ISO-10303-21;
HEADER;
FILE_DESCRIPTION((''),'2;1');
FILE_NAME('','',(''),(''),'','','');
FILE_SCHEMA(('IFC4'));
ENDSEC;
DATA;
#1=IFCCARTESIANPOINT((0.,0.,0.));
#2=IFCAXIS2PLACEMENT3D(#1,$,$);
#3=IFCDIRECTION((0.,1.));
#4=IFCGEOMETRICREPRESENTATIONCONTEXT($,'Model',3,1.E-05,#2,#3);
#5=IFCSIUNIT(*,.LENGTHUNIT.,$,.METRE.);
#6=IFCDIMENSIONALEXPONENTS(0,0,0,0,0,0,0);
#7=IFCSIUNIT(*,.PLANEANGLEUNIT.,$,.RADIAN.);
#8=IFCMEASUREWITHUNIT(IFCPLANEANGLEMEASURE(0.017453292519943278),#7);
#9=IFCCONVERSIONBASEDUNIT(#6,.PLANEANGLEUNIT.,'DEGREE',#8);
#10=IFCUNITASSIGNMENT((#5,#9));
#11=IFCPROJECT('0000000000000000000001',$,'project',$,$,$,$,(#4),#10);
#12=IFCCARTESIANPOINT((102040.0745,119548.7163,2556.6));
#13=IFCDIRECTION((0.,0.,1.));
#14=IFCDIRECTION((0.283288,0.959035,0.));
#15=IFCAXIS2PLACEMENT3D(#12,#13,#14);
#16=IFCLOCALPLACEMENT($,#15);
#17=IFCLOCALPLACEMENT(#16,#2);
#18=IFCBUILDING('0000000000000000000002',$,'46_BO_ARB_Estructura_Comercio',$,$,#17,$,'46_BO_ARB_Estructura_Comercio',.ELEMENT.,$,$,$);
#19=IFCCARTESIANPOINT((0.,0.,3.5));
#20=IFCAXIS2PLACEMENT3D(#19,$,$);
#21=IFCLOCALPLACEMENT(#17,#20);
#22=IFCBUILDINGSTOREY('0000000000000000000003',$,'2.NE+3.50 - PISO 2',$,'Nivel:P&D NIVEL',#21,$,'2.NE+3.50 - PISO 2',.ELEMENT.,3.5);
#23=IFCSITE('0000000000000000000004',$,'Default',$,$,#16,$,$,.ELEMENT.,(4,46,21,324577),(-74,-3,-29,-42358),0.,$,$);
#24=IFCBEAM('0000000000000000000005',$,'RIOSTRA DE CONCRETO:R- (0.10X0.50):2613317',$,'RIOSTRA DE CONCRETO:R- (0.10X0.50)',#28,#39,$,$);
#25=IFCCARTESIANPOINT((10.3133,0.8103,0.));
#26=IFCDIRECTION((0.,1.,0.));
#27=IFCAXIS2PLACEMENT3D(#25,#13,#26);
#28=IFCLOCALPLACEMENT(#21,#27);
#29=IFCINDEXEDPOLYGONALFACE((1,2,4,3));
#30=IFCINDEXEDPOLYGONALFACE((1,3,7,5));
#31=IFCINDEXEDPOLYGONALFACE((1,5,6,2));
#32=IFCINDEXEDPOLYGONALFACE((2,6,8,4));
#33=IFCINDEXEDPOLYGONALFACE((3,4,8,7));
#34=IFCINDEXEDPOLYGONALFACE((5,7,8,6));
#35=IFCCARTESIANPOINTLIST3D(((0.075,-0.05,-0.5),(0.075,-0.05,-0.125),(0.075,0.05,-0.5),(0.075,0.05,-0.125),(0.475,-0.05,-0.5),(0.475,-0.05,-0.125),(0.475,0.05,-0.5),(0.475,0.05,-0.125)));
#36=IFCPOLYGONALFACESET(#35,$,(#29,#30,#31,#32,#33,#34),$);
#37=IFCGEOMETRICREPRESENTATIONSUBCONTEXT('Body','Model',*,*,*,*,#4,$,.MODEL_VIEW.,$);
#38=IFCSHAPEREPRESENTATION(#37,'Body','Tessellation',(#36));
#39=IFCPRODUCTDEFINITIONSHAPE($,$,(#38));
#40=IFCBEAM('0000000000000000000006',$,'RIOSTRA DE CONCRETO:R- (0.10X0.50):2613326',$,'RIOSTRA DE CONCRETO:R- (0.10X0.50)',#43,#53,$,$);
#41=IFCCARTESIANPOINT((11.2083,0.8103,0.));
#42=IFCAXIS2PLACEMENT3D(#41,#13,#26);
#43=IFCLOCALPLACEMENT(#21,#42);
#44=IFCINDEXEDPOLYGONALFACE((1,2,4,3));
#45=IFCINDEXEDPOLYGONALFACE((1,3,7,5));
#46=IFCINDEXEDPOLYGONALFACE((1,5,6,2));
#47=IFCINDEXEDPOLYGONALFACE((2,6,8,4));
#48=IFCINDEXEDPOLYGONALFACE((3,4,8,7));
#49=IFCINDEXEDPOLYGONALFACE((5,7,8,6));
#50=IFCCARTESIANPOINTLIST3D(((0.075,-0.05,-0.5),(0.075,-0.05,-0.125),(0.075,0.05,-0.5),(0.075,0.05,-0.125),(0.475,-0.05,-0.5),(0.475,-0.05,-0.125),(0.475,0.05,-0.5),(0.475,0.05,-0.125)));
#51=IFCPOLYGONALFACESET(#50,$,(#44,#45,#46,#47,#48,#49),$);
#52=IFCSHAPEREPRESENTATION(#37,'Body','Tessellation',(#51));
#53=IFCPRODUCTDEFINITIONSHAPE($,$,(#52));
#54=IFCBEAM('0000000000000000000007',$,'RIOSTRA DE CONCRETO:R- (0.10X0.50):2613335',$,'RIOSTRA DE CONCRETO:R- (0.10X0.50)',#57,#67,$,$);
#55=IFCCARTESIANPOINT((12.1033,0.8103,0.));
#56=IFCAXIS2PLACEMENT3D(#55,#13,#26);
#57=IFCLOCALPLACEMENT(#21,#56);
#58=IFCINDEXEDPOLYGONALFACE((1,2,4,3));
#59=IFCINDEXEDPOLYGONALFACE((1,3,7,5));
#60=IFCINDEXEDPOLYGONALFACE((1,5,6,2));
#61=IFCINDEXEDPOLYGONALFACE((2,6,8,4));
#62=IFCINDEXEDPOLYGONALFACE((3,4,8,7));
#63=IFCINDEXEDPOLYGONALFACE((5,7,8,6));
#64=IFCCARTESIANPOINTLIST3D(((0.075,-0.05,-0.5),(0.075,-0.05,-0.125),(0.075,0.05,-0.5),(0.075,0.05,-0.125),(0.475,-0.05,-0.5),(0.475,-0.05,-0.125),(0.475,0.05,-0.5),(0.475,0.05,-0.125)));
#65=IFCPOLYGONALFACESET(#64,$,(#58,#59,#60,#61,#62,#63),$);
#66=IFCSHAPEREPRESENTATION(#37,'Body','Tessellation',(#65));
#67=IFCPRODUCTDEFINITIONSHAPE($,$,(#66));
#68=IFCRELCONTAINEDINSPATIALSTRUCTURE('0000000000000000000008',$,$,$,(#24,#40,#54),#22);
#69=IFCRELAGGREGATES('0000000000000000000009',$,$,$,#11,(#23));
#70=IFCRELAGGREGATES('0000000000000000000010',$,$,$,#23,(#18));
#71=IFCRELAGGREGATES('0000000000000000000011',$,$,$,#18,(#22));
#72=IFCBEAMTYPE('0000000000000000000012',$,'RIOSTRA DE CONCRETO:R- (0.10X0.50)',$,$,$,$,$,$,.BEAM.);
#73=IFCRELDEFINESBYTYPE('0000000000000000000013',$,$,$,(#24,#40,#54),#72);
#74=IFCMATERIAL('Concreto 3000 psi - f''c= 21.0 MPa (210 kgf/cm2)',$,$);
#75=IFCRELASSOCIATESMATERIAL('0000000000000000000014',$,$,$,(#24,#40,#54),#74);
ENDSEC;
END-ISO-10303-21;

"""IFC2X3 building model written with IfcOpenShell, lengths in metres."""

from ifc_helpers import new_model, entity, si_unit, converted_unit, direction, frame, frame_2d, origin, place, context, subcontext, project, spatial, rectangle, extrude, material, type_object, element, save


model = new_model("IFC2X3")

# Units and contexts
model_context = context("Model", 3, precision=1e-05, world=origin(), true_north=direction((0.0, 1.0)))
body_context = subcontext(model_context, "Body", "Model", "MODEL_VIEW")
ifc_project = project(units=[si_unit("LENGTHUNIT", "METRE"), converted_unit("PLANEANGLEUNIT", "DEGREE", entity("IfcPlaneAngleMeasure", 0.017453292519943278), si_unit("PLANEANGLEUNIT", "RADIAN"), dimensions=[0, 0, 0, 0, 0, 0, 0])], contexts=[model_context])

# Site, building, storey
site_placement = place(None, frame((102040.0745, 119548.7163, 2556.6), z_axis=(0.0, 0.0, 1.0), x_axis=(0.283288, 0.959035, 0.0)))
site = spatial("IfcSite", under=ifc_project, at=site_placement, Name="Default", CompositionType="ELEMENT", RefLatitude=(4, 46, 21, 324577), RefLongitude=(-74, -3, -29, -42358), RefElevation=0.0)
building_placement = place(site_placement, origin())
building = spatial("IfcBuilding", under=site, at=building_placement, Name="46_BO_ARB_Estructura_Comercio", LongName="46_BO_ARB_Estructura_Comercio", CompositionType="ELEMENT")
storey_placement = place(building_placement, frame((0.0, 0.0, 3.5)))
storey = spatial("IfcBuildingStorey", under=building, at=storey_placement, Name="2.NE+3.50 - PISO 2", ObjectType="Nivel:P&D NIVEL", LongName="2.NE+3.50 - PISO 2", CompositionType="ELEMENT", Elevation=3.5)

# Beams
ifc_material = material(Name="Concreto 3000 psi - f'c= 21.0 MPa (210 kgf/cm2)")
beam_type_1 = type_object("IfcBeamType", Name="RIOSTRA DE CONCRETO:R- (0.10X0.50)", PredefinedType="BEAM")
beam_1_placement = place(storey_placement, frame((10.3133, 0.8103, 0.0), z_axis=(0.0, 0.0, 1.0), x_axis=(0.0, 1.0, 0.0)))
element("IfcBeam", 1, at=beam_1_placement, inside=storey, type_object=beam_type_1, material=ifc_material, Name="RIOSTRA DE CONCRETO:R- (0.10X0.50):2613317", ObjectType="RIOSTRA DE CONCRETO:R- (0.10X0.50)", context=body_context, shape_type="SweptSolid", body=[
    extrude(rectangle(XDim=0.375, YDim=0.1, at=frame_2d((0.0, 0.0), x_axis=(1.0, 0.0))), frame((0.075, 0.0, -0.3125), z_axis=(1.0, 0.0, 0.0), x_axis=(0.0, 0.0, -1.0)), (0.0, 0.0, 1.0), 0.4),
])
beam_2_placement = place(storey_placement, frame((11.2083, 0.8103, 0.0), z_axis=(0.0, 0.0, 1.0), x_axis=(0.0, 1.0, 0.0)))
element("IfcBeam", 2, at=beam_2_placement, inside=storey, type_object=beam_type_1, material=ifc_material, Name="RIOSTRA DE CONCRETO:R- (0.10X0.50):2613326", ObjectType="RIOSTRA DE CONCRETO:R- (0.10X0.50)", context=body_context, shape_type="SweptSolid", body=[
    extrude(rectangle(XDim=0.375, YDim=0.1, at=frame_2d((0.0, 0.0), x_axis=(1.0, 0.0))), frame((0.075, 0.0, -0.3125), z_axis=(1.0, 0.0, 0.0), x_axis=(0.0, 0.0, -1.0)), (0.0, 0.0, 1.0), 0.4),
])
beam_3_placement = place(storey_placement, frame((12.1033, 0.8103, 0.0), z_axis=(0.0, 0.0, 1.0), x_axis=(0.0, 1.0, 0.0)))
element("IfcBeam", 3, at=beam_3_placement, inside=storey, type_object=beam_type_1, material=ifc_material, Name="RIOSTRA DE CONCRETO:R- (0.10X0.50):2613335", ObjectType="RIOSTRA DE CONCRETO:R- (0.10X0.50)", context=body_context, shape_type="SweptSolid", body=[
    extrude(rectangle(XDim=0.375, YDim=0.1, at=frame_2d((0.0, 0.0), x_axis=(1.0, 0.0))), frame((0.075, 0.0, -0.3125), z_axis=(1.0, 0.0, 0.0), x_axis=(0.0, 0.0, -1.0)), (0.0, 0.0, 1.0), 0.4),
])

save(model, "model.ifc")
